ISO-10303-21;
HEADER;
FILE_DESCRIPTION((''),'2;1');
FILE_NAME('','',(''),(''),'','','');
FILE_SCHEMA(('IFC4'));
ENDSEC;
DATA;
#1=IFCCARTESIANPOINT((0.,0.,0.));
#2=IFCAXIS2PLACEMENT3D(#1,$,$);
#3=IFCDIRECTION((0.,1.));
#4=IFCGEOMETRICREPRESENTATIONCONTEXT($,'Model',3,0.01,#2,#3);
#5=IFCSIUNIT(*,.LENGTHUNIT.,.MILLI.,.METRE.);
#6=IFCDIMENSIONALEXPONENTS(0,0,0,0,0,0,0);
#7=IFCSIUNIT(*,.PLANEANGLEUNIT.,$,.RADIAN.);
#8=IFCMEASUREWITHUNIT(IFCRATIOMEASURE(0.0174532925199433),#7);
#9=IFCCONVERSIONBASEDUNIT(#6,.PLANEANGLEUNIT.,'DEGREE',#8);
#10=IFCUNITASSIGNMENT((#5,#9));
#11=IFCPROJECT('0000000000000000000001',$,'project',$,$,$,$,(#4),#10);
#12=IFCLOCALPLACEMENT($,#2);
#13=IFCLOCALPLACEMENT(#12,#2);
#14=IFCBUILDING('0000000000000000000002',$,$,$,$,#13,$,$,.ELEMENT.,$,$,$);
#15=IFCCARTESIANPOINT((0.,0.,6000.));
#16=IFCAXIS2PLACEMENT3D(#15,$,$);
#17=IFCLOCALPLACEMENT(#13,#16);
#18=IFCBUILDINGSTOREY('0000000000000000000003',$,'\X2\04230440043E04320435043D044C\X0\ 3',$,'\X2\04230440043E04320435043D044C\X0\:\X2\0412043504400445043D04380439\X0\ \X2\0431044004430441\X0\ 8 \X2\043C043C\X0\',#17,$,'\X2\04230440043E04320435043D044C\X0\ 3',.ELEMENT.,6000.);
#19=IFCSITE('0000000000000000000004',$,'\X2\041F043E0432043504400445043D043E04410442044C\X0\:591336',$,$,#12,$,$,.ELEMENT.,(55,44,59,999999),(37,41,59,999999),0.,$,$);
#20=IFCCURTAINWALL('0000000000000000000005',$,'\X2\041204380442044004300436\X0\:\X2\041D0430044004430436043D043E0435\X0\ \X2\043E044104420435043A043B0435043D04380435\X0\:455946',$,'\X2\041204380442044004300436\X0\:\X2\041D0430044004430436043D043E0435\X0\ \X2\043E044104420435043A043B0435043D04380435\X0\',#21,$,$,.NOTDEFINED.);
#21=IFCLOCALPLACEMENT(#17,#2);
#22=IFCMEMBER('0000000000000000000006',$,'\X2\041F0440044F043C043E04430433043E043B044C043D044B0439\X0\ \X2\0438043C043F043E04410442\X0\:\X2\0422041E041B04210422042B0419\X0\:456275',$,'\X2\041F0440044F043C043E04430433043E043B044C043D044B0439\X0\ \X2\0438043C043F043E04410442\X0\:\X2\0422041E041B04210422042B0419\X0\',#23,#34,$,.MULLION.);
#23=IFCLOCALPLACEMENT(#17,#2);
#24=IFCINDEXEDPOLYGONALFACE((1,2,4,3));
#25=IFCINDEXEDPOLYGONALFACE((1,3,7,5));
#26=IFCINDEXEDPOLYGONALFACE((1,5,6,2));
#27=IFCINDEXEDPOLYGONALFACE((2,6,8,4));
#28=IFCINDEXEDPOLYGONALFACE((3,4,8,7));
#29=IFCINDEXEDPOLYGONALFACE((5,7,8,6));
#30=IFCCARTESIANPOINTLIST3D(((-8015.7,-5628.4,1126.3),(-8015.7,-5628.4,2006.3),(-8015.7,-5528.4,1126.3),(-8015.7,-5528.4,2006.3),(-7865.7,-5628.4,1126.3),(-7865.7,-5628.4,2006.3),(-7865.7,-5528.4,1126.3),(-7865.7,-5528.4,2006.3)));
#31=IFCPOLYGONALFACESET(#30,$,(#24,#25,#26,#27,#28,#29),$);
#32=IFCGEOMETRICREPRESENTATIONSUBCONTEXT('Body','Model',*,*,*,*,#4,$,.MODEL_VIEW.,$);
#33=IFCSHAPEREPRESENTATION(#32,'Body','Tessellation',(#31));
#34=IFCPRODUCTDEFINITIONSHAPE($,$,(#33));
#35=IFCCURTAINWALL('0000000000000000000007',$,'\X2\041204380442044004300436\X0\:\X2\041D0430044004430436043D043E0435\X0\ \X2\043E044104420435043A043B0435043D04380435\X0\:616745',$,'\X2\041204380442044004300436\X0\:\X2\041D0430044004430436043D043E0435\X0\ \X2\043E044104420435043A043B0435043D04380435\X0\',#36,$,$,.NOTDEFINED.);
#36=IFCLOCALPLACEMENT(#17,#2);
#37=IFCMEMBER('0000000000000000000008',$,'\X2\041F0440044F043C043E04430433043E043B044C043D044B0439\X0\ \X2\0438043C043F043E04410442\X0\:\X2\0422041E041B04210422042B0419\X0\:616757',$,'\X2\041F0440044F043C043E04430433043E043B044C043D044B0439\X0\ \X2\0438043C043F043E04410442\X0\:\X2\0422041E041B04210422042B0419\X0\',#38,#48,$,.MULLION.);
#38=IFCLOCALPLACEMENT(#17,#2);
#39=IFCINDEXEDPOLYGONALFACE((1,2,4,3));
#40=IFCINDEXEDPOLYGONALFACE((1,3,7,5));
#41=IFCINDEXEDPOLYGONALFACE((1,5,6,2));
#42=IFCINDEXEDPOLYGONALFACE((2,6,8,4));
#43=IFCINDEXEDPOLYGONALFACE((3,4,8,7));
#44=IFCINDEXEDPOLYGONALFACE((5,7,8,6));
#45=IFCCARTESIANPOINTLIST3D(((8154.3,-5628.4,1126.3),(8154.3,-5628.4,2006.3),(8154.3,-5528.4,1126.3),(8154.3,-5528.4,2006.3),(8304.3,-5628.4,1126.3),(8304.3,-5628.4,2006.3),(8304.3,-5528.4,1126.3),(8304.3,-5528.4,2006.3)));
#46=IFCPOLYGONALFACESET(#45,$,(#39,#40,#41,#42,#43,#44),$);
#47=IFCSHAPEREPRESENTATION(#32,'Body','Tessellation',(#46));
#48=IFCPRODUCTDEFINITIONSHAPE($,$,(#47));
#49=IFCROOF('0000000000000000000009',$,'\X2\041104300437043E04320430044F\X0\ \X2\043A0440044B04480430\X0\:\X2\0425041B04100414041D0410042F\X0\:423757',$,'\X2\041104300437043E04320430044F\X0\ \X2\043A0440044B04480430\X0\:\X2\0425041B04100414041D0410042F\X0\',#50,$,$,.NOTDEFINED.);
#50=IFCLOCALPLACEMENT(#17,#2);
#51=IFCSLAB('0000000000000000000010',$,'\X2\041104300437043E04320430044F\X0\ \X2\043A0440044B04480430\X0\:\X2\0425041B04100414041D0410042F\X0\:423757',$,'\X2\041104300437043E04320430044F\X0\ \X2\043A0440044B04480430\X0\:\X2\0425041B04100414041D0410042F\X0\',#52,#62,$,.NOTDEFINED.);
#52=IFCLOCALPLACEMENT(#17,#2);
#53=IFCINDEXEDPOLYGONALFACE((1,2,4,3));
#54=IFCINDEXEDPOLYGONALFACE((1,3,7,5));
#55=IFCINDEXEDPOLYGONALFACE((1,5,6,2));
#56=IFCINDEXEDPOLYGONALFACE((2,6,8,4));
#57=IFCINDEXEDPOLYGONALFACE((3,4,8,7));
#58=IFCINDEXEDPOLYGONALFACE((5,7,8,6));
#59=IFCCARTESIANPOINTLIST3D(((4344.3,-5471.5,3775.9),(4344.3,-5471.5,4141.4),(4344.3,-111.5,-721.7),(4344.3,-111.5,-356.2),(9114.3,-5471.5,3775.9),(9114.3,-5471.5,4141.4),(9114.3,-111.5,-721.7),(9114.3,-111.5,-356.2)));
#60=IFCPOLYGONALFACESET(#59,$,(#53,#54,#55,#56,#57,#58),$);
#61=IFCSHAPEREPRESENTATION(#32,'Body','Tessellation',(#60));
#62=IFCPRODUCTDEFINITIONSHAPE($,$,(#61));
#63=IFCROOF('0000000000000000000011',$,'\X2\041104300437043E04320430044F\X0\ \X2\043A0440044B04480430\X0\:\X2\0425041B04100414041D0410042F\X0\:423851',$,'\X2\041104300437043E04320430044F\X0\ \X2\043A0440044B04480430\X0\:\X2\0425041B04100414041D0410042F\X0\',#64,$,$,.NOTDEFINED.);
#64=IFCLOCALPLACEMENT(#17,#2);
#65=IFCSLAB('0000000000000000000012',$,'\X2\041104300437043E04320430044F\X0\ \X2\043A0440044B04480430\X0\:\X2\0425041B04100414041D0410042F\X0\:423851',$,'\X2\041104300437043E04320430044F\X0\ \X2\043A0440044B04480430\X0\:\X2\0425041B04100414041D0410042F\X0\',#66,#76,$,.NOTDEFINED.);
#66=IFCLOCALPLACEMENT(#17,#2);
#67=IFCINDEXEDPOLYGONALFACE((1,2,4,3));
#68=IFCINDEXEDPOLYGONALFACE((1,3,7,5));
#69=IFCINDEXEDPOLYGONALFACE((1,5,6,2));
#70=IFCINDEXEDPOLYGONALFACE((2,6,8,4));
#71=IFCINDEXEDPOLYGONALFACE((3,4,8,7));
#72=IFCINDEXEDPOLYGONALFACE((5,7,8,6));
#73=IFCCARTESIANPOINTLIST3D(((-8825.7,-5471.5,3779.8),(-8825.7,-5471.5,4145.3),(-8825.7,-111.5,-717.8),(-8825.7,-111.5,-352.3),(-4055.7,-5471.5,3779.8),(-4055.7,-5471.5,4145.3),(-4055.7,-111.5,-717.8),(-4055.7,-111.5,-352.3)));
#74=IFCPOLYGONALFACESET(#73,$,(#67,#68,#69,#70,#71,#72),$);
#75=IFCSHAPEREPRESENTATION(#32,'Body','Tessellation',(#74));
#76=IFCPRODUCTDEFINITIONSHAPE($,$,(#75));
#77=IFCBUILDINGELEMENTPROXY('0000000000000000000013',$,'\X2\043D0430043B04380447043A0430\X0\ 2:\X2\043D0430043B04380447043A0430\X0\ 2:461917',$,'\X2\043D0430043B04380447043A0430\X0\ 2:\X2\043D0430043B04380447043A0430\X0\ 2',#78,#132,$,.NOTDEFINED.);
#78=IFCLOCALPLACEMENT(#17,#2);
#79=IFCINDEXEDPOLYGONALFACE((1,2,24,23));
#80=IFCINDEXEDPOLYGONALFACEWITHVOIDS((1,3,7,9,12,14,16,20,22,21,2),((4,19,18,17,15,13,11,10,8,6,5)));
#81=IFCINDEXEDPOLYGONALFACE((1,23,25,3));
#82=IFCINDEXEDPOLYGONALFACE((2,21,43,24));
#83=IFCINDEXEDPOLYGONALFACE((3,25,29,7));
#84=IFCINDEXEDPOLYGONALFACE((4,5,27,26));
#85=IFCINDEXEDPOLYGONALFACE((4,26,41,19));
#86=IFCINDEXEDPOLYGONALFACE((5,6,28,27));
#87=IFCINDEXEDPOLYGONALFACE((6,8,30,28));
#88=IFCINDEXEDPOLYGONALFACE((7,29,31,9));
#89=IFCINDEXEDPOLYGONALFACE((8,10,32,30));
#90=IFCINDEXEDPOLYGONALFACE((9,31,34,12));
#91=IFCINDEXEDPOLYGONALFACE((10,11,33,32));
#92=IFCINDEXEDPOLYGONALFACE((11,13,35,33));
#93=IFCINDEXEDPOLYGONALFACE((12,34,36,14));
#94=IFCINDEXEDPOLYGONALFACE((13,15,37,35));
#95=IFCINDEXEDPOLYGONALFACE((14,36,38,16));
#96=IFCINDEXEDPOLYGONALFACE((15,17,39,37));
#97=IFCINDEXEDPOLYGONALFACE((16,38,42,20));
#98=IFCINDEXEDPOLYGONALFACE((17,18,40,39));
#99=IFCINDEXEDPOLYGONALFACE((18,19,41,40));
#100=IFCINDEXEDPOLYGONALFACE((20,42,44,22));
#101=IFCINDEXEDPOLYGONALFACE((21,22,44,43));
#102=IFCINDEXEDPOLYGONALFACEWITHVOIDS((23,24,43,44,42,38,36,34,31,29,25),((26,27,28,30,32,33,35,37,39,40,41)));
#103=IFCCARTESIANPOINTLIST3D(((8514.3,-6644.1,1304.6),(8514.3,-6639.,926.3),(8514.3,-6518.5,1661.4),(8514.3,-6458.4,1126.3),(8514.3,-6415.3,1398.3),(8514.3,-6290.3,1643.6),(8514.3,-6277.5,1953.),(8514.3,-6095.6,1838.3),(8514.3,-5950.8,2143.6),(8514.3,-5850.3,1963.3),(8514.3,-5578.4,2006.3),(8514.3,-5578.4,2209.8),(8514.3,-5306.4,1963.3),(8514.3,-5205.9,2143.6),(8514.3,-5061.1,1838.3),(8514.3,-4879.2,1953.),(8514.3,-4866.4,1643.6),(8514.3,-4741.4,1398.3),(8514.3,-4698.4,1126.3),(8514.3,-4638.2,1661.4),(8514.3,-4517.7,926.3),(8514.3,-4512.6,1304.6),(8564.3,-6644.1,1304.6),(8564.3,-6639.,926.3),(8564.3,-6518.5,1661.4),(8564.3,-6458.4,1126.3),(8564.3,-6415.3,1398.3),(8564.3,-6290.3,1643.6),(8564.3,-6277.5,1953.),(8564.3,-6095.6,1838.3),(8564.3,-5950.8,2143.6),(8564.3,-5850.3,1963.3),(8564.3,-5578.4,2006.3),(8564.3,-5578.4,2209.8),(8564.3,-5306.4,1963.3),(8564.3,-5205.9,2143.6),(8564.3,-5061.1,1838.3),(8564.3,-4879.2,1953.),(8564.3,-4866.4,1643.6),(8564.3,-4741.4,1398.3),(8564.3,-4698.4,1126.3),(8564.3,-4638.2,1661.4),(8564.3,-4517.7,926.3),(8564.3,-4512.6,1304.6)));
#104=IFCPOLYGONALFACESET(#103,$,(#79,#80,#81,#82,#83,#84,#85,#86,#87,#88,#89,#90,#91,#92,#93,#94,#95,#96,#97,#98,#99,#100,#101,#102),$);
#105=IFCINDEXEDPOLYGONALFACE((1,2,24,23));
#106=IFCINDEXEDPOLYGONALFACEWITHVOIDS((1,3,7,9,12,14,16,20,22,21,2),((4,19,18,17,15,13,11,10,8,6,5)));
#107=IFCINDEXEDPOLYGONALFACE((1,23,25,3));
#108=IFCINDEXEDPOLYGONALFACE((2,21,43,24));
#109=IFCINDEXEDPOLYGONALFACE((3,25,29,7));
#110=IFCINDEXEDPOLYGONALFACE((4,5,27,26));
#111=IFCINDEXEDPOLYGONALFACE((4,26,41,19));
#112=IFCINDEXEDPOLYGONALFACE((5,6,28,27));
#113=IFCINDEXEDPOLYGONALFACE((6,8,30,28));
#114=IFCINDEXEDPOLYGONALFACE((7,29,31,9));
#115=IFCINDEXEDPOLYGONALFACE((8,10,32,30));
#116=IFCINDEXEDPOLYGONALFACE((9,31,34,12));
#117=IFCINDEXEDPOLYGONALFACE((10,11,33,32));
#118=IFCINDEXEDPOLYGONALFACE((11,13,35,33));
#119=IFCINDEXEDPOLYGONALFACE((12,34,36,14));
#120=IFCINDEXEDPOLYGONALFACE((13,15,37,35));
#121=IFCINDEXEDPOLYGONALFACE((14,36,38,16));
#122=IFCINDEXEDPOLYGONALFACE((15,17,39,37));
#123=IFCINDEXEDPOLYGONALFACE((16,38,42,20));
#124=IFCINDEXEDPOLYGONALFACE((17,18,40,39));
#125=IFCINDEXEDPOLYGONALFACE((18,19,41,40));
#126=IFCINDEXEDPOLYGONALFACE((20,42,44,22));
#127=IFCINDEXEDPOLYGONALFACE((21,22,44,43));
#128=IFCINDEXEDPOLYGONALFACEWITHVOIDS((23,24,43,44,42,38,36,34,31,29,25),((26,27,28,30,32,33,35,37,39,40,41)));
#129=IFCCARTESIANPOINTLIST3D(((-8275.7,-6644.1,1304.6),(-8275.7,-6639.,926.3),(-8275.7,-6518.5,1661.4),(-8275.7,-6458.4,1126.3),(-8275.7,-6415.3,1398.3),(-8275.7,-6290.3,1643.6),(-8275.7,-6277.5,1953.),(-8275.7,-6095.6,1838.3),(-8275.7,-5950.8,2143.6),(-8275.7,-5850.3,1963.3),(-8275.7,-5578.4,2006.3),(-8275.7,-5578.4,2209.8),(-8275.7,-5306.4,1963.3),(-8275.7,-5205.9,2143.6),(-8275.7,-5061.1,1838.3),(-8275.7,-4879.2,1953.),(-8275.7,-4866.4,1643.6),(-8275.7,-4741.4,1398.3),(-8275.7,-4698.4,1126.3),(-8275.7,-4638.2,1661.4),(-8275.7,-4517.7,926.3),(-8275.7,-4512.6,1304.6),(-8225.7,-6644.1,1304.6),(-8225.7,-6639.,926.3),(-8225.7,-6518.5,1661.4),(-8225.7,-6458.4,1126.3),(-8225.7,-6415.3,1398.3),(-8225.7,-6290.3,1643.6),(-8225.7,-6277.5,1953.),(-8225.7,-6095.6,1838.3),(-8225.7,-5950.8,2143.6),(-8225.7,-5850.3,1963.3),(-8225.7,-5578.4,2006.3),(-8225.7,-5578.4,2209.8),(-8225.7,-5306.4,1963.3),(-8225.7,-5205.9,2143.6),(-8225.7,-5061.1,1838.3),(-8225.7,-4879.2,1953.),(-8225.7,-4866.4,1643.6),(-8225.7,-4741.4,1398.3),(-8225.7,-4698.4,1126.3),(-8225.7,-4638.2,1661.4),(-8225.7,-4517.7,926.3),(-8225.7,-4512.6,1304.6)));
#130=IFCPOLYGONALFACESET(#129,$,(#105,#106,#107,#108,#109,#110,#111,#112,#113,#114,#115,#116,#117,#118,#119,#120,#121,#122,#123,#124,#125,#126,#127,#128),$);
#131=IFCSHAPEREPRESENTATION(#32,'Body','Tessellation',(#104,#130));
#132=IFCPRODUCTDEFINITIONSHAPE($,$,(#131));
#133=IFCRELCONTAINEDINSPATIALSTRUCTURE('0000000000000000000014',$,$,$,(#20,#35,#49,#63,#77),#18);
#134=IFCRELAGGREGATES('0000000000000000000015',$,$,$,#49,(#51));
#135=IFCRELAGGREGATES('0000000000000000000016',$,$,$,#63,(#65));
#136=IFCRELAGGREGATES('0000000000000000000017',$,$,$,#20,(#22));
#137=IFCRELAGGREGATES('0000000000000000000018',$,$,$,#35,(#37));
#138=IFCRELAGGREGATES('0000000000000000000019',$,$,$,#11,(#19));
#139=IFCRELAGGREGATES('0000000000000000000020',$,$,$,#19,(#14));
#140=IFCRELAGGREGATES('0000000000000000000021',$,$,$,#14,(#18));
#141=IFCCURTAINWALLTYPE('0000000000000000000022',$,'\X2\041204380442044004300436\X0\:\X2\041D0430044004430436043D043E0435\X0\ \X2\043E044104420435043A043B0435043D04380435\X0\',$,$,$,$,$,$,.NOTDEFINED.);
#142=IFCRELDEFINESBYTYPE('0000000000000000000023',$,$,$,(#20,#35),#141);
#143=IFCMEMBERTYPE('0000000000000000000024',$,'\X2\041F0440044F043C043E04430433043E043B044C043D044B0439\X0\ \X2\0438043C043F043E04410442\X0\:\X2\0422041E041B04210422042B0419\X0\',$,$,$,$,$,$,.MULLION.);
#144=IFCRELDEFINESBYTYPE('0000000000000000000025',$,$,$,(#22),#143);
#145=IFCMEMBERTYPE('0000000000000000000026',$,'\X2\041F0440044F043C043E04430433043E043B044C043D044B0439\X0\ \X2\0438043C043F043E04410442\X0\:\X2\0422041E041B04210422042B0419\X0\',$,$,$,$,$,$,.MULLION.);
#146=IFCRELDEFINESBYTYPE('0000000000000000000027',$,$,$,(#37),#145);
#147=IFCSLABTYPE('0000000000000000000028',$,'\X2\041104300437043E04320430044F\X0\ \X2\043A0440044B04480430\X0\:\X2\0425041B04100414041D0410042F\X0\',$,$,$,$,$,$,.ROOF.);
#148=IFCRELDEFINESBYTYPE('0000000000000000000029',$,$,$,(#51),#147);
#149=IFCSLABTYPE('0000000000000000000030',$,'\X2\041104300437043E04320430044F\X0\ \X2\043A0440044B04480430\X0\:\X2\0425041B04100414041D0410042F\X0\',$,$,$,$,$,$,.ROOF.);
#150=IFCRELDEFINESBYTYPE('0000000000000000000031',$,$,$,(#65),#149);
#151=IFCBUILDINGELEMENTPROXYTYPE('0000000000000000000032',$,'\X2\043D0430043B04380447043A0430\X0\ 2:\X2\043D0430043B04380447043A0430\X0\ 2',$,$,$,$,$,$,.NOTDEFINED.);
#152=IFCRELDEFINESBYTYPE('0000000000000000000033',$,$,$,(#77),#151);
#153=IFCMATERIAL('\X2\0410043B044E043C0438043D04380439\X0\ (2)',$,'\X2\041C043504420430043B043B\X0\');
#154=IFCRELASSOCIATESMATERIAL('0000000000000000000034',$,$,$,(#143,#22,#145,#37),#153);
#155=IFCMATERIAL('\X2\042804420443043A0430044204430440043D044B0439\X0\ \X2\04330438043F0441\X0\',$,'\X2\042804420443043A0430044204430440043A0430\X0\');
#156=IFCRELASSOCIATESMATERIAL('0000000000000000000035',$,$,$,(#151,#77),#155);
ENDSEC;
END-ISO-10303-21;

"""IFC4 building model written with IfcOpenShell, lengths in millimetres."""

from ifc_helpers import new_model, entity, si_unit, converted_unit, direction, frame, origin, place, context, subcontext, project, spatial, indexed_curve, outline, extrude, source, transform, mapped, material, type_object, type_shapes, element, aggregate, save


model = new_model("IFC4")

# Units and contexts
model_context = context("Model", 3, precision=0.01, world=origin(), true_north=direction((0.0, 1.0)))
body_context = subcontext(model_context, "Body", "Model", "MODEL_VIEW")
ifc_project = project(units=[si_unit("LENGTHUNIT", "METRE", prefix="MILLI"), converted_unit("PLANEANGLEUNIT", "DEGREE", entity("IfcRatioMeasure", 0.0174532925199433), si_unit("PLANEANGLEUNIT", "RADIAN"), dimensions=[0, 0, 0, 0, 0, 0, 0])], contexts=[model_context])

# Site, building, storey
site_placement = place(None, origin())
site = spatial("IfcSite", under=ifc_project, at=site_placement, Name="Поверхность:591336", CompositionType="ELEMENT", RefLatitude=(55, 44, 59, 999999), RefLongitude=(37, 41, 59, 999999), RefElevation=0.0)
building_placement = place(site_placement, origin())
building = spatial("IfcBuilding", under=site, at=building_placement, CompositionType="ELEMENT")
storey_placement = place(building_placement, frame((0.0, 0.0, 6000.0)))
storey = spatial("IfcBuildingStorey", under=building, at=storey_placement, Name="Уровень 3", ObjectType="Уровень:Верхний брус 8 мм", LongName="Уровень 3", CompositionType="ELEMENT", Elevation=6000.0)

# Curtain walls, members
curtain_wall_type = type_object("IfcCurtainWallType", Name="Витраж:Наружное остекление", PredefinedType="NOTDEFINED")
curtain_wall_1_placement = place(storey_placement, frame((0.0, 0.0, -6000.0)))
curtain_wall_1 = element("IfcCurtainWall", 1, at=curtain_wall_1_placement, inside=storey, type_object=curtain_wall_type, Name="Витраж:Наружное остекление:455946", ObjectType="Витраж:Наружное остекление", PredefinedType="NOTDEFINED")
ifc_material_1 = material(Name="Алюминий (2)", Category="Металл")
member_type_1 = type_object("IfcMemberType", Name="Прямоугольный импост:ТОЛСТЫЙ", PredefinedType="MULLION", material=ifc_material_1)
shared_shape_1 = source(origin(), body_context, "Body", "SweptSolid", [
    extrude(outline(indexed_curve([(-75.0, -50.0), (75.0, -50.0), (75.0, 50.0), (-75.0, 50.0), (-75.0, -50.0)], self_intersect=False)), frame((0.0, 0.0, -880.0), z_axis=(0.0, 0.0, 1.0), x_axis=(0.0, -1.0, 0.0)), (0.0, 0.0, 1.0), 880.0),
])
type_shapes(member_type_1, [shared_shape_1])
member_1_placement = place(storey_placement, frame((-7940.7, -5578.4, 1126.3), z_axis=(0.0, 0.0, -1.0), x_axis=(0.0, -1.0, 0.0)))
member_1 = element("IfcMember", 2, at=member_1_placement, type_object=member_type_1, material=ifc_material_1, Name="Прямоугольный импост:ТОЛСТЫЙ:456275", ObjectType="Прямоугольный импост:ТОЛСТЫЙ", PredefinedType="MULLION", context=body_context, shape_type="MappedRepresentation", body=[
    mapped(shared_shape_1, transform((0.0, 0.0, 0.0), scale=1.0)),
])
curtain_wall_2_placement = place(storey_placement, frame((0.0, 0.0, -6000.0)))
curtain_wall_2 = element("IfcCurtainWall", 3, at=curtain_wall_2_placement, inside=storey, type_object=curtain_wall_type, Name="Витраж:Наружное остекление:616745", ObjectType="Витраж:Наружное остекление", PredefinedType="NOTDEFINED")
member_type_2 = type_object("IfcMemberType", Name="Прямоугольный импост:ТОЛСТЫЙ", PredefinedType="MULLION", material=ifc_material_1)
shared_shape_2 = source(origin(), body_context, "Body", "SweptSolid", [
    extrude(outline(indexed_curve([(-75.0, -50.0), (75.0, -50.0), (75.0, 50.0), (-75.0, 50.0), (-75.0, -50.0)], self_intersect=False)), frame((0.0, 0.0, -880.0), z_axis=(0.0, 0.0, 1.0), x_axis=(0.0, -1.0, 0.0)), (0.0, 0.0, 1.0), 880.0),
])
type_shapes(member_type_2, [shared_shape_2])
member_2_placement = place(storey_placement, frame((8229.3, -5578.4, 1126.3), z_axis=(0.0, 0.0, -1.0), x_axis=(0.0, -1.0, 0.0)))
member_2 = element("IfcMember", 4, at=member_2_placement, type_object=member_type_2, material=ifc_material_1, Name="Прямоугольный импост:ТОЛСТЫЙ:616757", ObjectType="Прямоугольный импост:ТОЛСТЫЙ", PredefinedType="MULLION", context=body_context, shape_type="MappedRepresentation", body=[
    mapped(shared_shape_2, transform((0.0, 0.0, 0.0), scale=1.0)),
])

# Roofs, slabs
roof_1_placement = place(storey_placement, frame((4344.3, -5471.5, -721.7)))
roof_1 = element("IfcRoof", 5, at=roof_1_placement, inside=storey, Name="Базовая крыша:ХЛАДНАЯ:423757", ObjectType="Базовая крыша:ХЛАДНАЯ", PredefinedType="NOTDEFINED")
slab_type_1 = type_object("IfcSlabType", Name="Базовая крыша:ХЛАДНАЯ", PredefinedType="ROOF")
slab_1_placement = place(roof_1_placement, origin())
slab_1 = element("IfcSlab", 6, at=slab_1_placement, type_object=slab_type_1, Name="Базовая крыша:ХЛАДНАЯ:423757", ObjectType="Базовая крыша:ХЛАДНАЯ", PredefinedType="NOTDEFINED", context=body_context, shape_type="SweptSolid", body=[
    extrude(outline(indexed_curve([(2385.0, 3498.5), (-2385.0, 3498.5), (-2385.0, -3498.5), (2385.0, -3498.5), (2385.0, 3498.5)], self_intersect=False)), frame((2385.0, 2680.0, 2248.8), z_axis=(0.0, 0.642788, 0.766044), x_axis=(1.0, 0.0, 0.0)), (0.0, -0.642788, 0.766044), 365.5),
])
aggregate(roof_1, [slab_1])
roof_2_placement = place(storey_placement, frame((-8825.7, -5471.5, -717.8)))
roof_2 = element("IfcRoof", 7, at=roof_2_placement, inside=storey, Name="Базовая крыша:ХЛАДНАЯ:423851", ObjectType="Базовая крыша:ХЛАДНАЯ", PredefinedType="NOTDEFINED")
slab_type_2 = type_object("IfcSlabType", Name="Базовая крыша:ХЛАДНАЯ", PredefinedType="ROOF")
slab_2_placement = place(roof_2_placement, origin())
slab_2 = element("IfcSlab", 8, at=slab_2_placement, type_object=slab_type_2, Name="Базовая крыша:ХЛАДНАЯ:423851", ObjectType="Базовая крыша:ХЛАДНАЯ", PredefinedType="NOTDEFINED", context=body_context, shape_type="SweptSolid", body=[
    extrude(outline(indexed_curve([(-2385.0, -3498.5), (2385.0, -3498.5), (2385.0, 3498.5), (-2385.0, 3498.5), (-2385.0, -3498.5)], self_intersect=False)), frame((2385.0, 2680.0, 2248.8), z_axis=(0.0, 0.642788, 0.766044), x_axis=(1.0, 0.0, 0.0)), (0.0, -0.642788, 0.766044), 365.5),
])
aggregate(roof_2, [slab_2])

aggregate(curtain_wall_1, [member_1])
aggregate(curtain_wall_2, [member_2])

# Building element proxy
ifc_material_2 = material(Name="Штукатурный гипс", Category="Штукатурка")
building_element_proxy_type = type_object("IfcBuildingElementProxyType", Name="наличка 2:наличка 2", PredefinedType="NOTDEFINED", material=ifc_material_2)
shared_shape_3 = source(origin(), body_context, "Body", "SweptSolid", [
    extrude(outline(indexed_curve([(-1060.7, 0.0), (1060.7, 0.0), (1065.8, 378.2), (940.1, 735.0), (699.2, 1026.6), (372.4, 1217.2), (0.0, 1283.5), (-372.4, 1217.2), (-699.2, 1026.6), (-940.1, 735.0), (-1065.8, 378.2), (-1060.7, 0.0)], self_intersect=False), holes=[indexed_curve([(880.0, 200.0), (-880.0, 200.0), (-836.9, 471.9), (-711.9, 717.3), (-517.3, 911.9), (-271.9, 1036.9), (0.0, 1080.0), (271.9, 1036.9), (517.3, 911.9), (711.9, 717.3), (836.9, 471.9), (880.0, 200.0)], self_intersect=False)]), frame((8514.3, -5578.4, 6926.3), z_axis=(1.0, 0.0, 0.0), x_axis=(0.0, 1.0, 0.0)), (0.0, 0.0, 1.0), 50.0),
    extrude(outline(indexed_curve([(-1060.7, 0.0), (1060.7, 0.0), (1065.8, 378.2), (940.1, 735.0), (699.2, 1026.6), (372.4, 1217.2), (0.0, 1283.5), (-372.4, 1217.2), (-699.2, 1026.6), (-940.1, 735.0), (-1065.8, 378.2), (-1060.7, 0.0)], self_intersect=False), holes=[indexed_curve([(880.0, 200.0), (-880.0, 200.0), (-836.9, 471.9), (-711.9, 717.3), (-517.3, 911.9), (-271.9, 1036.9), (0.0, 1080.0), (271.9, 1036.9), (517.3, 911.9), (711.9, 717.3), (836.9, 471.9), (880.0, 200.0)], self_intersect=False)]), frame((-8275.7, -5578.4, 6926.3), z_axis=(1.0, 0.0, 0.0), x_axis=(0.0, 1.0, 0.0)), (0.0, 0.0, 1.0), 50.0),
])
type_shapes(building_element_proxy_type, [shared_shape_3])
proxy_placement = place(storey_placement, frame((0.0, 0.0, -6000.0)))
element("IfcBuildingElementProxy", 9, at=proxy_placement, inside=storey, type_object=building_element_proxy_type, material=ifc_material_2, Name="наличка 2:наличка 2:461917", ObjectType="наличка 2:наличка 2", PredefinedType="NOTDEFINED", context=body_context, shape_type="MappedRepresentation", body=[
    mapped(shared_shape_3, transform((0.0, 0.0, 0.0), scale=1.0)),
])

save(model, "model.ifc")
